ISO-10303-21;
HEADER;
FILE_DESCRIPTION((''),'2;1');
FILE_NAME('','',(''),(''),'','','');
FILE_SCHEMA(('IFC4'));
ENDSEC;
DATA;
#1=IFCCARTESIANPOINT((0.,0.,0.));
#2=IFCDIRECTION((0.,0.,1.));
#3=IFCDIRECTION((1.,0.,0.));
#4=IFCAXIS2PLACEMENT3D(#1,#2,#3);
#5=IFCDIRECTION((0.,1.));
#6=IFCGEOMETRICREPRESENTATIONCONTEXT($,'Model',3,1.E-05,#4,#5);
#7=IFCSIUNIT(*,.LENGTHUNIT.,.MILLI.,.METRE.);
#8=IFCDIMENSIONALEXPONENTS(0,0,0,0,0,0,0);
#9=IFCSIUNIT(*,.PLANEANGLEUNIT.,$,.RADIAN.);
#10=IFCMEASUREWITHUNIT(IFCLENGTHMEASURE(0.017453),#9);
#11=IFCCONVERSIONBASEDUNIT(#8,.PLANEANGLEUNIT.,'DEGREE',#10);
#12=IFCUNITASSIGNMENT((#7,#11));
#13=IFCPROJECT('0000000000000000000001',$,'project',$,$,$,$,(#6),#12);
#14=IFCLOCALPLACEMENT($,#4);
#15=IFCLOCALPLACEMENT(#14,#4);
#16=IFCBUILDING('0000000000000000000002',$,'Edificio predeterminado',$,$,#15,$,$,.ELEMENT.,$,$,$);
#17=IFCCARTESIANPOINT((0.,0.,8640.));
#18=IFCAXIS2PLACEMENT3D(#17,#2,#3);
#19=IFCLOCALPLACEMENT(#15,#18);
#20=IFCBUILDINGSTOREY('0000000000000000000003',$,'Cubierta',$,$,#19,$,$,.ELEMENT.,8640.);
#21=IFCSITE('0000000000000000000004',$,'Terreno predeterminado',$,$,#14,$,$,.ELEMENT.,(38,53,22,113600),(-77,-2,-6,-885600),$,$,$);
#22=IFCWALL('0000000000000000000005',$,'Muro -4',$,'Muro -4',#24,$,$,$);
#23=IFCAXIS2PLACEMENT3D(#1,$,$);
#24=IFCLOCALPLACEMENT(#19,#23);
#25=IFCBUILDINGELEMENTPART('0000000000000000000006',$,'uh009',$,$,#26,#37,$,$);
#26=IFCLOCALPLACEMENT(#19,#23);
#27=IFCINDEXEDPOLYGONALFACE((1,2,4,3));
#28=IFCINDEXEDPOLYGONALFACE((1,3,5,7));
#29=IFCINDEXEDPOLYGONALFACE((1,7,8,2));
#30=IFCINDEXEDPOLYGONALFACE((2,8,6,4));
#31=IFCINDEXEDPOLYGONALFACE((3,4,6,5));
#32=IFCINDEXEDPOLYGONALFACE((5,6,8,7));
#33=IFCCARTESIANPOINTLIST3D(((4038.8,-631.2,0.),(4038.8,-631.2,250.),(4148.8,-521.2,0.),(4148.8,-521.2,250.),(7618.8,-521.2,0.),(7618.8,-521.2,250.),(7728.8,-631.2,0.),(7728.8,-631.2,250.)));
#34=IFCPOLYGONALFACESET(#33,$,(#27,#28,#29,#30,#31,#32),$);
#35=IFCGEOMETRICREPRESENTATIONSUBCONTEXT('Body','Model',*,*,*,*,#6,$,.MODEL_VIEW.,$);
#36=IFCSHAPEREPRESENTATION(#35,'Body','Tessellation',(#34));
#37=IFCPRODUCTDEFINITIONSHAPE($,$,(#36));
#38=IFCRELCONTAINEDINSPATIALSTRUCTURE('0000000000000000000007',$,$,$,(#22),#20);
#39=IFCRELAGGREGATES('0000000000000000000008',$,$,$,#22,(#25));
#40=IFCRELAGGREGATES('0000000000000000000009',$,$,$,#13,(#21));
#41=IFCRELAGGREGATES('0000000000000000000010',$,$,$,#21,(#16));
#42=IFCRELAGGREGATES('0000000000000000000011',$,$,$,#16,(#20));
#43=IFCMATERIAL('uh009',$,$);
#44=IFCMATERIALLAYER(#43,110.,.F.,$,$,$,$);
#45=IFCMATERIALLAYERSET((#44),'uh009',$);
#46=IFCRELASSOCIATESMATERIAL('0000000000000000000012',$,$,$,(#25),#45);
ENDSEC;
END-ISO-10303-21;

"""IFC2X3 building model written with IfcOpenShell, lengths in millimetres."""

from ifc_helpers import new_model, entity, si_unit, converted_unit, direction, frame, origin_with_axes, place, context, subcontext, project, spatial, polyline, outline, extrude, material, layer, layer_set, layer_usage, element, aggregate, save


model = new_model("IFC2X3")

# Units and contexts
model_context = context("Model", 3, precision=1e-05, world=origin_with_axes(), true_north=direction((0.0, 1.0)))
body_context = subcontext(model_context, "Body", "Model", "MODEL_VIEW")
ifc_project = project(units=[si_unit("LENGTHUNIT", "METRE", prefix="MILLI"), converted_unit("PLANEANGLEUNIT", "DEGREE", entity("IfcLengthMeasure", 0.017453), si_unit("PLANEANGLEUNIT", "RADIAN"), dimensions=[0, 0, 0, 0, 0, 0, 0])], contexts=[model_context])

# Site, building, storey
site_placement = place(None, origin_with_axes())
site = spatial("IfcSite", under=ifc_project, at=site_placement, Name="Terreno predeterminado", CompositionType="ELEMENT", RefLatitude=(38, 53, 22, 113600), RefLongitude=(-77, -2, -6, -885600))
building_placement = place(site_placement, origin_with_axes())
building = spatial("IfcBuilding", under=site, at=building_placement, Name="Edificio predeterminado", CompositionType="ELEMENT")
storey_placement = place(building_placement, frame((0.0, 0.0, 8640.0), z_axis=(0.0, 0.0, 1.0), x_axis=(1.0, 0.0, 0.0)))
storey = spatial("IfcBuildingStorey", under=building, at=storey_placement, Name="Cubierta", CompositionType="ELEMENT", Elevation=8640.0)

# Wall, building element part
wall_1_placement = place(storey_placement, frame((7673.8, -576.2, 0.0), z_axis=(0.0, 0.0, 1.0), x_axis=(-1.0, 0.0, 0.0)))
wall_1 = element("IfcWall", 1, at=wall_1_placement, inside=storey, Name="Muro -4", ObjectType="Muro -4")
ifc_material_1 = material(Name="uh009")
ifc_layer_1 = layer(ifc_material_1, 110.0, ventilated=False)
ifc_layer_set_1 = layer_set([ifc_layer_1], Name="uh009")
ifc_layer_usage_1 = layer_usage(ifc_layer_set_1, "AXIS2", "NEGATIVE", -55.0)
building_element_part_1_placement = place(wall_1_placement, origin_with_axes())
building_element_part_1 = element("IfcBuildingElementPart", 2, at=building_element_part_1_placement, material=ifc_layer_usage_1, Name="uh009", context=body_context, shape_type="SweptSolid", body=[
    extrude(outline(polyline([(3635.0, 55.0), (3525.0, -55.0), (55.0, -55.0), (-55.0, 55.0), (3635.0, 55.0)])), origin_with_axes(), (0.0, 0.0, 1.0), 250.0),
])
aggregate(wall_1, [building_element_part_1])

save(model, "model.ifc")
